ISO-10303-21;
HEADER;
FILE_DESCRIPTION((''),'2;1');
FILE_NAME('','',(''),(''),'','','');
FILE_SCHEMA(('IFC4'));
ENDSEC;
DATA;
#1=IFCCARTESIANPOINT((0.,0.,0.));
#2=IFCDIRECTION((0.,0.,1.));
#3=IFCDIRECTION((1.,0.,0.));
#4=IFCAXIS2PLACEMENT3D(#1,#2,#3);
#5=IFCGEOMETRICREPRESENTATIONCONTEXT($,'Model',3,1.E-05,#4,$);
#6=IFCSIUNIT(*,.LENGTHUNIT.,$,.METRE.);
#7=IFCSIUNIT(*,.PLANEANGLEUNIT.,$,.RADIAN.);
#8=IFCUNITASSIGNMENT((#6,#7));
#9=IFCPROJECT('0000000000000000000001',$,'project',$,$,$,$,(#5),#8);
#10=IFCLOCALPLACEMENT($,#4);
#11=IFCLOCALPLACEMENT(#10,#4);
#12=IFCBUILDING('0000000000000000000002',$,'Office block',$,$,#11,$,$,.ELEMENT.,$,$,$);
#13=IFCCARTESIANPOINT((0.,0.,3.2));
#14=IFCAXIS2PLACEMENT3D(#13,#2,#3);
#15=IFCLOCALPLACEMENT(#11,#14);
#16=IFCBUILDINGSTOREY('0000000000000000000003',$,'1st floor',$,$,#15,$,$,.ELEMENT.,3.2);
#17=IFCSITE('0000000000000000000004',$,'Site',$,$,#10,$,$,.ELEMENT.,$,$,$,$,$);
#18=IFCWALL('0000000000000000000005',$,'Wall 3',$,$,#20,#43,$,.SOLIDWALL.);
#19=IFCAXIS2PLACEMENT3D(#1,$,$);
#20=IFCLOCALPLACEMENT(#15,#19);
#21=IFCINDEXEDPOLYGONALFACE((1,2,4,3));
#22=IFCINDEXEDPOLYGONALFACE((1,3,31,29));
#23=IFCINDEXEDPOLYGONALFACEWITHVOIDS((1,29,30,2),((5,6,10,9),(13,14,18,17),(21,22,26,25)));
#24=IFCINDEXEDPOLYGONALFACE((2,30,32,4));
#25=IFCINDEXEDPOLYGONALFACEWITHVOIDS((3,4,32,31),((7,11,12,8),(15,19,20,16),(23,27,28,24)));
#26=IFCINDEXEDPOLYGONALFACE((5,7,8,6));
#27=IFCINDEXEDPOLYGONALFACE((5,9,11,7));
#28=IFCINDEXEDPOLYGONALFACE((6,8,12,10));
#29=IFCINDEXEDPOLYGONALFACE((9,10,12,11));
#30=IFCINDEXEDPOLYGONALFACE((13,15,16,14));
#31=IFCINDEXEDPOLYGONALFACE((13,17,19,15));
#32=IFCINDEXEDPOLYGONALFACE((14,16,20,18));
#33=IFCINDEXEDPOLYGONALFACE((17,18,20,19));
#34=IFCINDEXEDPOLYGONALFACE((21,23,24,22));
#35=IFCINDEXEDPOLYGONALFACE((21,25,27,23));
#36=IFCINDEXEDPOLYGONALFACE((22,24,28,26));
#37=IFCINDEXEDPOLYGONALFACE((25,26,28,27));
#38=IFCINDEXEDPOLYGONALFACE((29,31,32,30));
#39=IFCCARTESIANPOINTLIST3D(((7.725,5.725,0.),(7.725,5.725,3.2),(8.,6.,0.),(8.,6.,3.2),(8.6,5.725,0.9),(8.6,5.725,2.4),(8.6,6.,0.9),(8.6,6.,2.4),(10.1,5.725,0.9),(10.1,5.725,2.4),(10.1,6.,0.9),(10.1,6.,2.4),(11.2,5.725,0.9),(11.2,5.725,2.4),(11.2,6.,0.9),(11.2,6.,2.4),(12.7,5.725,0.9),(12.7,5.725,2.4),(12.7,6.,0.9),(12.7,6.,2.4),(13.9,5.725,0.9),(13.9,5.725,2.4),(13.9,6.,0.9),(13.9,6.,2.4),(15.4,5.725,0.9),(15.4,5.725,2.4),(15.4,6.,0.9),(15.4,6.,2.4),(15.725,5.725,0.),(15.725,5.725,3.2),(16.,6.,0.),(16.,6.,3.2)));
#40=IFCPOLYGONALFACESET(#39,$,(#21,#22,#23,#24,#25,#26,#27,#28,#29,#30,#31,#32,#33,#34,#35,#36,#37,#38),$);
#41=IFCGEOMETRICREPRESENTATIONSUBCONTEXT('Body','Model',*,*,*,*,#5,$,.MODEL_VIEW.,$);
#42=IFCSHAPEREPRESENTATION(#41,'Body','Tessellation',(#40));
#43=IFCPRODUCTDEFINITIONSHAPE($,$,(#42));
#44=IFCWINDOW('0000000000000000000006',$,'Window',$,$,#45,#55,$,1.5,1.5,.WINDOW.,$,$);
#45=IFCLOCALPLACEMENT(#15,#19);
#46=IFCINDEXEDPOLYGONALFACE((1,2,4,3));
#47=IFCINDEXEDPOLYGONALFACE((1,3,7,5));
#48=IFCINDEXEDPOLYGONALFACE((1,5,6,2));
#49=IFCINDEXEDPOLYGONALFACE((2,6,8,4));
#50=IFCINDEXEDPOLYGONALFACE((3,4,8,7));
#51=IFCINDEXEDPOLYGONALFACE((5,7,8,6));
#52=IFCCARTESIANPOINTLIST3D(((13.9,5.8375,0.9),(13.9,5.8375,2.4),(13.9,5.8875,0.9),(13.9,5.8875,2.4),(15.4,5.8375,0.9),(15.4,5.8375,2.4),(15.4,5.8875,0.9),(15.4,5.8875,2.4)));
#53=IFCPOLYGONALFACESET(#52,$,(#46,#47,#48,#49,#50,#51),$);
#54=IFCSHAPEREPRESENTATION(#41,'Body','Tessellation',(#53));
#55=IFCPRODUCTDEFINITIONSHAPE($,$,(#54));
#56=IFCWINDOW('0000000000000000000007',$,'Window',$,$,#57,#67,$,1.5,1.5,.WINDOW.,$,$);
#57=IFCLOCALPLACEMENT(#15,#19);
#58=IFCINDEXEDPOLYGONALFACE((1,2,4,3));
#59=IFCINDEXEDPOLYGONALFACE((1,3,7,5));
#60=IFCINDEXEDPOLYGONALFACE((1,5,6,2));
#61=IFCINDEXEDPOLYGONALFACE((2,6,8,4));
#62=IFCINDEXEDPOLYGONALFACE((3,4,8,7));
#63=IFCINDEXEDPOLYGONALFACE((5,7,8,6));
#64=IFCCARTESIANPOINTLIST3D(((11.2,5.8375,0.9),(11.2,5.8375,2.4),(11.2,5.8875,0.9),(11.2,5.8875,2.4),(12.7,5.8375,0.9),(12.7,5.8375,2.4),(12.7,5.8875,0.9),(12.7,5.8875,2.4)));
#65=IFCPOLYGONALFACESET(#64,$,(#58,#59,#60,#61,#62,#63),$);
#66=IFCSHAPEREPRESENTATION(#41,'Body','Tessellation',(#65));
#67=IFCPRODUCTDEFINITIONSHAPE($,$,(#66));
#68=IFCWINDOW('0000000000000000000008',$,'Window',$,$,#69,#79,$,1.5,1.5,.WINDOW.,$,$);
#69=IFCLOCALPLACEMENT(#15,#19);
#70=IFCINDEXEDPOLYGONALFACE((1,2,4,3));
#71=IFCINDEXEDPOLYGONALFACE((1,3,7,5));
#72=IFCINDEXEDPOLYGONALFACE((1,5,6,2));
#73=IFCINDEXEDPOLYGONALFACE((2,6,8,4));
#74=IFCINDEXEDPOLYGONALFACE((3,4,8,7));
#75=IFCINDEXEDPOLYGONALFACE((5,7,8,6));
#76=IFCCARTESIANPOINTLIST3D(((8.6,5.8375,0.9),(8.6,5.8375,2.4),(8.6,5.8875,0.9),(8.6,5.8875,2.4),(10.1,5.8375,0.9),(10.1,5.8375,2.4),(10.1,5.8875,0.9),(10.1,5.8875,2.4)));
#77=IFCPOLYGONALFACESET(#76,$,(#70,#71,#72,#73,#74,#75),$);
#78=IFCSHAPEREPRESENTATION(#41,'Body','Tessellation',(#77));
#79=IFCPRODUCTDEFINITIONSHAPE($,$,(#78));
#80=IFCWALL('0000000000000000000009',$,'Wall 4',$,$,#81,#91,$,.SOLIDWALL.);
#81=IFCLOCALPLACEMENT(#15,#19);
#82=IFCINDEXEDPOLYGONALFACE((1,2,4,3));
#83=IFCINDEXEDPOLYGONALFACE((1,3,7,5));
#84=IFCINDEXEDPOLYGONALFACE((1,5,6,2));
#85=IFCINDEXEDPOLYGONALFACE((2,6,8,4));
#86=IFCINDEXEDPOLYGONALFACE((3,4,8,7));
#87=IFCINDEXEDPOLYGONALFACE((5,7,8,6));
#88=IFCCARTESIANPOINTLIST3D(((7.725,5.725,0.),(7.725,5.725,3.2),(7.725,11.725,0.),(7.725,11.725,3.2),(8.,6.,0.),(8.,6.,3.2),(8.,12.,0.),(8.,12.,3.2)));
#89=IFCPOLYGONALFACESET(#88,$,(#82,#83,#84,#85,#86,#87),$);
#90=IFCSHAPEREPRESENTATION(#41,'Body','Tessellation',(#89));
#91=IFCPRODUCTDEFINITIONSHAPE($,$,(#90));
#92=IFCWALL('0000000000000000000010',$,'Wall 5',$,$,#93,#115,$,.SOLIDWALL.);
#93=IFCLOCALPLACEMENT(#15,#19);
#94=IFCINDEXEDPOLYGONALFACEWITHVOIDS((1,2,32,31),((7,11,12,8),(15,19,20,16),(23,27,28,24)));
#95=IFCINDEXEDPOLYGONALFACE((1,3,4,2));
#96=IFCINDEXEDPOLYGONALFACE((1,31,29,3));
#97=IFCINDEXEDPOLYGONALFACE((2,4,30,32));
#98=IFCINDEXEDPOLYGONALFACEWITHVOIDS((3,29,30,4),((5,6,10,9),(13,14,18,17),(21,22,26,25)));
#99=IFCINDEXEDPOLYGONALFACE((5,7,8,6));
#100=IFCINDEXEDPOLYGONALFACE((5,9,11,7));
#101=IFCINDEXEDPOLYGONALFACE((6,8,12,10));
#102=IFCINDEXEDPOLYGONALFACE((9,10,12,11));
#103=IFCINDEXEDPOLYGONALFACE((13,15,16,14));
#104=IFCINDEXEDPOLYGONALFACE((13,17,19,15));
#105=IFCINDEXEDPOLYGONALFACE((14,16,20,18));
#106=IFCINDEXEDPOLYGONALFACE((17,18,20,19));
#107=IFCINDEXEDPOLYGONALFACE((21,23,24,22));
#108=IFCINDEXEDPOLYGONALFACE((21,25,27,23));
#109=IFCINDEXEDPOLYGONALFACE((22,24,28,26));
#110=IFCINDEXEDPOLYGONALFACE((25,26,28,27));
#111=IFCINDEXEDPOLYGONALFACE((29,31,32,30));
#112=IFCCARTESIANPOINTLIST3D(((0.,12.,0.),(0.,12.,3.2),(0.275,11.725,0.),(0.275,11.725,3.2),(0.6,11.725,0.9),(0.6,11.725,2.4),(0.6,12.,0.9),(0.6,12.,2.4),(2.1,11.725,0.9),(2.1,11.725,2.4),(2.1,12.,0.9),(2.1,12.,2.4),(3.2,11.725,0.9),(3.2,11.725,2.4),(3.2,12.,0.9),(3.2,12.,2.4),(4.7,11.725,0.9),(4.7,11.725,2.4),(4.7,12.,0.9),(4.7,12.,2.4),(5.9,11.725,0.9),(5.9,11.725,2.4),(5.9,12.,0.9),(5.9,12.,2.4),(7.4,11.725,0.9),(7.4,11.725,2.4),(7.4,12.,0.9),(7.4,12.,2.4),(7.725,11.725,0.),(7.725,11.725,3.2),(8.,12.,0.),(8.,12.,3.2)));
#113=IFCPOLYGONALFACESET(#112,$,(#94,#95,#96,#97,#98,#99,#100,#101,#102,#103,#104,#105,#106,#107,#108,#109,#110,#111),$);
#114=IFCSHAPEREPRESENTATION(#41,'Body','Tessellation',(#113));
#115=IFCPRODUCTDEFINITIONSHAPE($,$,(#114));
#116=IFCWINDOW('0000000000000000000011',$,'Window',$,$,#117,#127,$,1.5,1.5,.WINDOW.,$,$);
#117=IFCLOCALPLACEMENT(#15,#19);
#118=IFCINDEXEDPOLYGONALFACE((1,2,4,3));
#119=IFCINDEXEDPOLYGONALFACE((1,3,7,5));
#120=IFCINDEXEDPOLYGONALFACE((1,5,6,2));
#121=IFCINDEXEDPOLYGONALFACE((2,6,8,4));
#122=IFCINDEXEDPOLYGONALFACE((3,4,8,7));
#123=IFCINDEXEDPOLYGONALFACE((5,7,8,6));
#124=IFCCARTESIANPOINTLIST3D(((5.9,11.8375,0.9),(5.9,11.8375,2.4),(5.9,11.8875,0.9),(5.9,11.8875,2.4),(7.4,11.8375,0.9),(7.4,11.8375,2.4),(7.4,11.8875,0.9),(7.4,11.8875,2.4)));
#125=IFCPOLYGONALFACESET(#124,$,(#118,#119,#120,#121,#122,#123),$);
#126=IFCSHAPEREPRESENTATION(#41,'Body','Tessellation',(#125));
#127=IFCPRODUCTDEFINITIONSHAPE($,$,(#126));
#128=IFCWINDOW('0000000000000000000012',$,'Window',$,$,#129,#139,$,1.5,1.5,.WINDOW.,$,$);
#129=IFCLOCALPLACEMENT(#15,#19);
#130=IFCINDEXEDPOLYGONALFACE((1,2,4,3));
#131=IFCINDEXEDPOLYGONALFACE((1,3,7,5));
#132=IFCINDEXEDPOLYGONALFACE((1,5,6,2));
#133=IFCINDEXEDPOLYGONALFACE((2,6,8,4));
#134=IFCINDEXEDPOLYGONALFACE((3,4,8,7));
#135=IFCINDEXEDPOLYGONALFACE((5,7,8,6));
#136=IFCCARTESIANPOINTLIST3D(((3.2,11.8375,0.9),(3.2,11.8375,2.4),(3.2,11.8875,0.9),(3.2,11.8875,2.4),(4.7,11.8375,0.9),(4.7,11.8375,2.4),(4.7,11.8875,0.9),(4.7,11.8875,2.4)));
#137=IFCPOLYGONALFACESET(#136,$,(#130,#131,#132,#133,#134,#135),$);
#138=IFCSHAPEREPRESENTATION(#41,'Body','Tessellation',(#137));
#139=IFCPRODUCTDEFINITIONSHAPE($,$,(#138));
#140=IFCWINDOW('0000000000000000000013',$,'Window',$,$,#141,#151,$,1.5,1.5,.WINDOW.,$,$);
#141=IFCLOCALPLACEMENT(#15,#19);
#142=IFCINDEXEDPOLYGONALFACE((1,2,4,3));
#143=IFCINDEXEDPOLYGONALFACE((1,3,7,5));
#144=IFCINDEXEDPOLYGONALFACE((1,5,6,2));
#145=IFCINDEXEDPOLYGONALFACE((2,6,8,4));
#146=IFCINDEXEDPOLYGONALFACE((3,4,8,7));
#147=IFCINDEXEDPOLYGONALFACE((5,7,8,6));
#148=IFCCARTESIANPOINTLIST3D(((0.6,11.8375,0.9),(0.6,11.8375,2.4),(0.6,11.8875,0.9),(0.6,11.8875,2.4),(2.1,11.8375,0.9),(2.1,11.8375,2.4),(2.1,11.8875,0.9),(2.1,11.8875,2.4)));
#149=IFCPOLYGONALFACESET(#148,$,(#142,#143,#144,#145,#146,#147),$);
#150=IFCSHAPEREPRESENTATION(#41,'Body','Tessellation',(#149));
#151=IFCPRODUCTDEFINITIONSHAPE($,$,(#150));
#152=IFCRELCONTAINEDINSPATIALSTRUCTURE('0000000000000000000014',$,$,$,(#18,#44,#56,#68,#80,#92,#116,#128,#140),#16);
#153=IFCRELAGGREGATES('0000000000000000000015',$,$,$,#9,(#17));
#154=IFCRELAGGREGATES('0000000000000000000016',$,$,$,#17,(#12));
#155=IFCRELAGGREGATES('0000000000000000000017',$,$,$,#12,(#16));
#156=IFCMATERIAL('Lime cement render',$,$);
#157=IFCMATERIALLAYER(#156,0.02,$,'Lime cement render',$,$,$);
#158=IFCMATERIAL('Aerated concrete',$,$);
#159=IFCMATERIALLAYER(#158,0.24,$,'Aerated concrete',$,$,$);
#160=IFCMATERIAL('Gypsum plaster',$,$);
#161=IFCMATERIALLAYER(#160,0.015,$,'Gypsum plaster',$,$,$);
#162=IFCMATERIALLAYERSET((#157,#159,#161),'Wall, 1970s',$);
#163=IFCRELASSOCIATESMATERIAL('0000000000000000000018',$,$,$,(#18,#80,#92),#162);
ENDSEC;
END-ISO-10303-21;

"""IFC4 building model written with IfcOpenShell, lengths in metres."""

from ifc_helpers import new_model, si_unit, frame, origin_with_axes, place, context, subcontext, project, spatial, polyline, outline, extrude, material, layer, layer_set, layer_usage, element, fill, save


model = new_model("IFC4")

# Units and contexts
model_context = context("Model", 3, precision=1e-05, world=origin_with_axes())
body_context = subcontext(model_context, "Body", "Model", "MODEL_VIEW")
ifc_project = project(units=[si_unit("LENGTHUNIT", "METRE"), si_unit("PLANEANGLEUNIT", "RADIAN")], contexts=[model_context])

# Site, building, storey
site_placement = place(None, origin_with_axes())
site = spatial("IfcSite", under=ifc_project, at=site_placement, Name="Site", CompositionType="ELEMENT")
building_placement = place(site_placement, origin_with_axes())
building = spatial("IfcBuilding", under=site, at=building_placement, Name="Office block", CompositionType="ELEMENT")
storey_placement = place(building_placement, frame((0.0, 0.0, 3.2), z_axis=(0.0, 0.0, 1.0), x_axis=(1.0, 0.0, 0.0)))
storey = spatial("IfcBuildingStorey", under=building, at=storey_placement, Name="1st floor", CompositionType="ELEMENT", Elevation=3.2)

# Wall, openings, windows
ifc_material_1 = material(Name="Lime cement render")
ifc_layer_1 = layer(ifc_material_1, 0.02, Name="Lime cement render")
ifc_material_2 = material(Name="Aerated concrete")
ifc_layer_2 = layer(ifc_material_2, 0.24, Name="Aerated concrete")
ifc_material_3 = material(Name="Gypsum plaster")
ifc_layer_3 = layer(ifc_material_3, 0.015, Name="Gypsum plaster")
ifc_layer_set = layer_set([ifc_layer_1, ifc_layer_2, ifc_layer_3], Name="Wall, 1970s")
ifc_layer_usage_1 = layer_usage(ifc_layer_set, "AXIS2", "NEGATIVE", 0.0)
wall_1_placement = place(storey_placement, origin_with_axes())
wall_1 = element("IfcWall", 1, at=wall_1_placement, inside=storey, material=ifc_layer_usage_1, Name="Wall 3", PredefinedType="SOLIDWALL", context=body_context, shape_type="SweptSolid", body=[
    extrude(outline(polyline([(16.0, 6.0), (8.0, 6.0), (7.725, 5.725), (15.725, 5.725), (16.0, 6.0)])), origin_with_axes(), (0.0, 0.0, 1.0), 3.2),
])
opening_1_placement = place(storey_placement, origin_with_axes())
opening_1 = element("IfcOpeningElement", 2, at=opening_1_placement, cuts=wall_1, PredefinedType="OPENING", context=body_context, shape_type="SweptSolid", body=[
    extrude(outline(polyline([(15.4, 6.01), (13.9, 6.01), (13.9, 5.715), (15.4, 5.715), (15.4, 6.01)])), frame((0.0, 0.0, 0.9), z_axis=(0.0, 0.0, 1.0), x_axis=(1.0, 0.0, 0.0)), (0.0, 0.0, 1.0), 1.5),
])
opening_2_placement = place(storey_placement, origin_with_axes())
opening_2 = element("IfcOpeningElement", 3, at=opening_2_placement, cuts=wall_1, PredefinedType="OPENING", context=body_context, shape_type="SweptSolid", body=[
    extrude(outline(polyline([(12.7, 6.01), (11.2, 6.01), (11.2, 5.715), (12.7, 5.715), (12.7, 6.01)])), frame((0.0, 0.0, 0.9), z_axis=(0.0, 0.0, 1.0), x_axis=(1.0, 0.0, 0.0)), (0.0, 0.0, 1.0), 1.5),
])
opening_3_placement = place(storey_placement, origin_with_axes())
opening_3 = element("IfcOpeningElement", 4, at=opening_3_placement, cuts=wall_1, PredefinedType="OPENING", context=body_context, shape_type="SweptSolid", body=[
    extrude(outline(polyline([(10.1, 6.01), (8.6, 6.01), (8.6, 5.715), (10.1, 5.715), (10.1, 6.01)])), frame((0.0, 0.0, 0.9), z_axis=(0.0, 0.0, 1.0), x_axis=(1.0, 0.0, 0.0)), (0.0, 0.0, 1.0), 1.5),
])
window_1_placement = place(storey_placement, origin_with_axes())
window_1 = element("IfcWindow", 5, at=window_1_placement, inside=storey, Name="Window", OverallHeight=1.5, OverallWidth=1.5, PredefinedType="WINDOW", context=body_context, shape_type="SweptSolid", body=[
    extrude(outline(polyline([(15.4, 5.8875), (13.9, 5.8875), (13.9, 5.8375), (15.4, 5.8375), (15.4, 5.8875)])), frame((0.0, 0.0, 0.9), z_axis=(0.0, 0.0, 1.0), x_axis=(1.0, 0.0, 0.0)), (0.0, 0.0, 1.0), 1.5),
])
fill(opening_1, window_1)
window_2_placement = place(storey_placement, origin_with_axes())
window_2 = element("IfcWindow", 6, at=window_2_placement, inside=storey, Name="Window", OverallHeight=1.5, OverallWidth=1.5, PredefinedType="WINDOW", context=body_context, shape_type="SweptSolid", body=[
    extrude(outline(polyline([(12.7, 5.8875), (11.2, 5.8875), (11.2, 5.8375), (12.7, 5.8375), (12.7, 5.8875)])), frame((0.0, 0.0, 0.9), z_axis=(0.0, 0.0, 1.0), x_axis=(1.0, 0.0, 0.0)), (0.0, 0.0, 1.0), 1.5),
])
fill(opening_2, window_2)
window_3_placement = place(storey_placement, origin_with_axes())
window_3 = element("IfcWindow", 7, at=window_3_placement, inside=storey, Name="Window", OverallHeight=1.5, OverallWidth=1.5, PredefinedType="WINDOW", context=body_context, shape_type="SweptSolid", body=[
    extrude(outline(polyline([(10.1, 5.8875), (8.6, 5.8875), (8.6, 5.8375), (10.1, 5.8375), (10.1, 5.8875)])), frame((0.0, 0.0, 0.9), z_axis=(0.0, 0.0, 1.0), x_axis=(1.0, 0.0, 0.0)), (0.0, 0.0, 1.0), 1.5),
])
fill(opening_3, window_3)

# Wall
ifc_layer_usage_2 = layer_usage(ifc_layer_set, "AXIS2", "NEGATIVE", 0.0)
wall_2_placement = place(storey_placement, origin_with_axes())
element("IfcWall", 8, at=wall_2_placement, inside=storey, material=ifc_layer_usage_2, Name="Wall 4", PredefinedType="SOLIDWALL", context=body_context, shape_type="SweptSolid", body=[
    extrude(outline(polyline([(8.0, 6.0), (8.0, 12.0), (7.725, 11.725), (7.725, 5.725), (8.0, 6.0)])), origin_with_axes(), (0.0, 0.0, 1.0), 3.2),
])

# Wall, openings, windows
ifc_layer_usage_3 = layer_usage(ifc_layer_set, "AXIS2", "NEGATIVE", 0.0)
wall_3_placement = place(storey_placement, origin_with_axes())
wall_3 = element("IfcWall", 9, at=wall_3_placement, inside=storey, material=ifc_layer_usage_3, Name="Wall 5", PredefinedType="SOLIDWALL", context=body_context, shape_type="SweptSolid", body=[
    extrude(outline(polyline([(8.0, 12.0), (0.0, 12.0), (0.275, 11.725), (7.725, 11.725), (8.0, 12.0)])), origin_with_axes(), (0.0, 0.0, 1.0), 3.2),
])
opening_4_placement = place(storey_placement, origin_with_axes())
opening_4 = element("IfcOpeningElement", 10, at=opening_4_placement, cuts=wall_3, PredefinedType="OPENING", context=body_context, shape_type="SweptSolid", body=[
    extrude(outline(polyline([(7.4, 12.01), (5.9, 12.01), (5.9, 11.715), (7.4, 11.715), (7.4, 12.01)])), frame((0.0, 0.0, 0.9), z_axis=(0.0, 0.0, 1.0), x_axis=(1.0, 0.0, 0.0)), (0.0, 0.0, 1.0), 1.5),
])
opening_5_placement = place(storey_placement, origin_with_axes())
opening_5 = element("IfcOpeningElement", 11, at=opening_5_placement, cuts=wall_3, PredefinedType="OPENING", context=body_context, shape_type="SweptSolid", body=[
    extrude(outline(polyline([(4.7, 12.01), (3.2, 12.01), (3.2, 11.715), (4.7, 11.715), (4.7, 12.01)])), frame((0.0, 0.0, 0.9), z_axis=(0.0, 0.0, 1.0), x_axis=(1.0, 0.0, 0.0)), (0.0, 0.0, 1.0), 1.5),
])
opening_6_placement = place(storey_placement, origin_with_axes())
opening_6 = element("IfcOpeningElement", 12, at=opening_6_placement, cuts=wall_3, PredefinedType="OPENING", context=body_context, shape_type="SweptSolid", body=[
    extrude(outline(polyline([(2.1, 12.01), (0.6, 12.01), (0.6, 11.715), (2.1, 11.715), (2.1, 12.01)])), frame((0.0, 0.0, 0.9), z_axis=(0.0, 0.0, 1.0), x_axis=(1.0, 0.0, 0.0)), (0.0, 0.0, 1.0), 1.5),
])
window_4_placement = place(storey_placement, origin_with_axes())
window_4 = element("IfcWindow", 13, at=window_4_placement, inside=storey, Name="Window", OverallHeight=1.5, OverallWidth=1.5, PredefinedType="WINDOW", context=body_context, shape_type="SweptSolid", body=[
    extrude(outline(polyline([(7.4, 11.8875), (5.9, 11.8875), (5.9, 11.8375), (7.4, 11.8375), (7.4, 11.8875)])), frame((0.0, 0.0, 0.9), z_axis=(0.0, 0.0, 1.0), x_axis=(1.0, 0.0, 0.0)), (0.0, 0.0, 1.0), 1.5),
])
fill(opening_4, window_4)
window_5_placement = place(storey_placement, origin_with_axes())
window_5 = element("IfcWindow", 14, at=window_5_placement, inside=storey, Name="Window", OverallHeight=1.5, OverallWidth=1.5, PredefinedType="WINDOW", context=body_context, shape_type="SweptSolid", body=[
    extrude(outline(polyline([(4.7, 11.8875), (3.2, 11.8875), (3.2, 11.8375), (4.7, 11.8375), (4.7, 11.8875)])), frame((0.0, 0.0, 0.9), z_axis=(0.0, 0.0, 1.0), x_axis=(1.0, 0.0, 0.0)), (0.0, 0.0, 1.0), 1.5),
])
fill(opening_5, window_5)
window_6_placement = place(storey_placement, origin_with_axes())
window_6 = element("IfcWindow", 15, at=window_6_placement, inside=storey, Name="Window", OverallHeight=1.5, OverallWidth=1.5, PredefinedType="WINDOW", context=body_context, shape_type="SweptSolid", body=[
    extrude(outline(polyline([(2.1, 11.8875), (0.6, 11.8875), (0.6, 11.8375), (2.1, 11.8375), (2.1, 11.8875)])), frame((0.0, 0.0, 0.9), z_axis=(0.0, 0.0, 1.0), x_axis=(1.0, 0.0, 0.0)), (0.0, 0.0, 1.0), 1.5),
])
fill(opening_6, window_6)

save(model, "model.ifc")
